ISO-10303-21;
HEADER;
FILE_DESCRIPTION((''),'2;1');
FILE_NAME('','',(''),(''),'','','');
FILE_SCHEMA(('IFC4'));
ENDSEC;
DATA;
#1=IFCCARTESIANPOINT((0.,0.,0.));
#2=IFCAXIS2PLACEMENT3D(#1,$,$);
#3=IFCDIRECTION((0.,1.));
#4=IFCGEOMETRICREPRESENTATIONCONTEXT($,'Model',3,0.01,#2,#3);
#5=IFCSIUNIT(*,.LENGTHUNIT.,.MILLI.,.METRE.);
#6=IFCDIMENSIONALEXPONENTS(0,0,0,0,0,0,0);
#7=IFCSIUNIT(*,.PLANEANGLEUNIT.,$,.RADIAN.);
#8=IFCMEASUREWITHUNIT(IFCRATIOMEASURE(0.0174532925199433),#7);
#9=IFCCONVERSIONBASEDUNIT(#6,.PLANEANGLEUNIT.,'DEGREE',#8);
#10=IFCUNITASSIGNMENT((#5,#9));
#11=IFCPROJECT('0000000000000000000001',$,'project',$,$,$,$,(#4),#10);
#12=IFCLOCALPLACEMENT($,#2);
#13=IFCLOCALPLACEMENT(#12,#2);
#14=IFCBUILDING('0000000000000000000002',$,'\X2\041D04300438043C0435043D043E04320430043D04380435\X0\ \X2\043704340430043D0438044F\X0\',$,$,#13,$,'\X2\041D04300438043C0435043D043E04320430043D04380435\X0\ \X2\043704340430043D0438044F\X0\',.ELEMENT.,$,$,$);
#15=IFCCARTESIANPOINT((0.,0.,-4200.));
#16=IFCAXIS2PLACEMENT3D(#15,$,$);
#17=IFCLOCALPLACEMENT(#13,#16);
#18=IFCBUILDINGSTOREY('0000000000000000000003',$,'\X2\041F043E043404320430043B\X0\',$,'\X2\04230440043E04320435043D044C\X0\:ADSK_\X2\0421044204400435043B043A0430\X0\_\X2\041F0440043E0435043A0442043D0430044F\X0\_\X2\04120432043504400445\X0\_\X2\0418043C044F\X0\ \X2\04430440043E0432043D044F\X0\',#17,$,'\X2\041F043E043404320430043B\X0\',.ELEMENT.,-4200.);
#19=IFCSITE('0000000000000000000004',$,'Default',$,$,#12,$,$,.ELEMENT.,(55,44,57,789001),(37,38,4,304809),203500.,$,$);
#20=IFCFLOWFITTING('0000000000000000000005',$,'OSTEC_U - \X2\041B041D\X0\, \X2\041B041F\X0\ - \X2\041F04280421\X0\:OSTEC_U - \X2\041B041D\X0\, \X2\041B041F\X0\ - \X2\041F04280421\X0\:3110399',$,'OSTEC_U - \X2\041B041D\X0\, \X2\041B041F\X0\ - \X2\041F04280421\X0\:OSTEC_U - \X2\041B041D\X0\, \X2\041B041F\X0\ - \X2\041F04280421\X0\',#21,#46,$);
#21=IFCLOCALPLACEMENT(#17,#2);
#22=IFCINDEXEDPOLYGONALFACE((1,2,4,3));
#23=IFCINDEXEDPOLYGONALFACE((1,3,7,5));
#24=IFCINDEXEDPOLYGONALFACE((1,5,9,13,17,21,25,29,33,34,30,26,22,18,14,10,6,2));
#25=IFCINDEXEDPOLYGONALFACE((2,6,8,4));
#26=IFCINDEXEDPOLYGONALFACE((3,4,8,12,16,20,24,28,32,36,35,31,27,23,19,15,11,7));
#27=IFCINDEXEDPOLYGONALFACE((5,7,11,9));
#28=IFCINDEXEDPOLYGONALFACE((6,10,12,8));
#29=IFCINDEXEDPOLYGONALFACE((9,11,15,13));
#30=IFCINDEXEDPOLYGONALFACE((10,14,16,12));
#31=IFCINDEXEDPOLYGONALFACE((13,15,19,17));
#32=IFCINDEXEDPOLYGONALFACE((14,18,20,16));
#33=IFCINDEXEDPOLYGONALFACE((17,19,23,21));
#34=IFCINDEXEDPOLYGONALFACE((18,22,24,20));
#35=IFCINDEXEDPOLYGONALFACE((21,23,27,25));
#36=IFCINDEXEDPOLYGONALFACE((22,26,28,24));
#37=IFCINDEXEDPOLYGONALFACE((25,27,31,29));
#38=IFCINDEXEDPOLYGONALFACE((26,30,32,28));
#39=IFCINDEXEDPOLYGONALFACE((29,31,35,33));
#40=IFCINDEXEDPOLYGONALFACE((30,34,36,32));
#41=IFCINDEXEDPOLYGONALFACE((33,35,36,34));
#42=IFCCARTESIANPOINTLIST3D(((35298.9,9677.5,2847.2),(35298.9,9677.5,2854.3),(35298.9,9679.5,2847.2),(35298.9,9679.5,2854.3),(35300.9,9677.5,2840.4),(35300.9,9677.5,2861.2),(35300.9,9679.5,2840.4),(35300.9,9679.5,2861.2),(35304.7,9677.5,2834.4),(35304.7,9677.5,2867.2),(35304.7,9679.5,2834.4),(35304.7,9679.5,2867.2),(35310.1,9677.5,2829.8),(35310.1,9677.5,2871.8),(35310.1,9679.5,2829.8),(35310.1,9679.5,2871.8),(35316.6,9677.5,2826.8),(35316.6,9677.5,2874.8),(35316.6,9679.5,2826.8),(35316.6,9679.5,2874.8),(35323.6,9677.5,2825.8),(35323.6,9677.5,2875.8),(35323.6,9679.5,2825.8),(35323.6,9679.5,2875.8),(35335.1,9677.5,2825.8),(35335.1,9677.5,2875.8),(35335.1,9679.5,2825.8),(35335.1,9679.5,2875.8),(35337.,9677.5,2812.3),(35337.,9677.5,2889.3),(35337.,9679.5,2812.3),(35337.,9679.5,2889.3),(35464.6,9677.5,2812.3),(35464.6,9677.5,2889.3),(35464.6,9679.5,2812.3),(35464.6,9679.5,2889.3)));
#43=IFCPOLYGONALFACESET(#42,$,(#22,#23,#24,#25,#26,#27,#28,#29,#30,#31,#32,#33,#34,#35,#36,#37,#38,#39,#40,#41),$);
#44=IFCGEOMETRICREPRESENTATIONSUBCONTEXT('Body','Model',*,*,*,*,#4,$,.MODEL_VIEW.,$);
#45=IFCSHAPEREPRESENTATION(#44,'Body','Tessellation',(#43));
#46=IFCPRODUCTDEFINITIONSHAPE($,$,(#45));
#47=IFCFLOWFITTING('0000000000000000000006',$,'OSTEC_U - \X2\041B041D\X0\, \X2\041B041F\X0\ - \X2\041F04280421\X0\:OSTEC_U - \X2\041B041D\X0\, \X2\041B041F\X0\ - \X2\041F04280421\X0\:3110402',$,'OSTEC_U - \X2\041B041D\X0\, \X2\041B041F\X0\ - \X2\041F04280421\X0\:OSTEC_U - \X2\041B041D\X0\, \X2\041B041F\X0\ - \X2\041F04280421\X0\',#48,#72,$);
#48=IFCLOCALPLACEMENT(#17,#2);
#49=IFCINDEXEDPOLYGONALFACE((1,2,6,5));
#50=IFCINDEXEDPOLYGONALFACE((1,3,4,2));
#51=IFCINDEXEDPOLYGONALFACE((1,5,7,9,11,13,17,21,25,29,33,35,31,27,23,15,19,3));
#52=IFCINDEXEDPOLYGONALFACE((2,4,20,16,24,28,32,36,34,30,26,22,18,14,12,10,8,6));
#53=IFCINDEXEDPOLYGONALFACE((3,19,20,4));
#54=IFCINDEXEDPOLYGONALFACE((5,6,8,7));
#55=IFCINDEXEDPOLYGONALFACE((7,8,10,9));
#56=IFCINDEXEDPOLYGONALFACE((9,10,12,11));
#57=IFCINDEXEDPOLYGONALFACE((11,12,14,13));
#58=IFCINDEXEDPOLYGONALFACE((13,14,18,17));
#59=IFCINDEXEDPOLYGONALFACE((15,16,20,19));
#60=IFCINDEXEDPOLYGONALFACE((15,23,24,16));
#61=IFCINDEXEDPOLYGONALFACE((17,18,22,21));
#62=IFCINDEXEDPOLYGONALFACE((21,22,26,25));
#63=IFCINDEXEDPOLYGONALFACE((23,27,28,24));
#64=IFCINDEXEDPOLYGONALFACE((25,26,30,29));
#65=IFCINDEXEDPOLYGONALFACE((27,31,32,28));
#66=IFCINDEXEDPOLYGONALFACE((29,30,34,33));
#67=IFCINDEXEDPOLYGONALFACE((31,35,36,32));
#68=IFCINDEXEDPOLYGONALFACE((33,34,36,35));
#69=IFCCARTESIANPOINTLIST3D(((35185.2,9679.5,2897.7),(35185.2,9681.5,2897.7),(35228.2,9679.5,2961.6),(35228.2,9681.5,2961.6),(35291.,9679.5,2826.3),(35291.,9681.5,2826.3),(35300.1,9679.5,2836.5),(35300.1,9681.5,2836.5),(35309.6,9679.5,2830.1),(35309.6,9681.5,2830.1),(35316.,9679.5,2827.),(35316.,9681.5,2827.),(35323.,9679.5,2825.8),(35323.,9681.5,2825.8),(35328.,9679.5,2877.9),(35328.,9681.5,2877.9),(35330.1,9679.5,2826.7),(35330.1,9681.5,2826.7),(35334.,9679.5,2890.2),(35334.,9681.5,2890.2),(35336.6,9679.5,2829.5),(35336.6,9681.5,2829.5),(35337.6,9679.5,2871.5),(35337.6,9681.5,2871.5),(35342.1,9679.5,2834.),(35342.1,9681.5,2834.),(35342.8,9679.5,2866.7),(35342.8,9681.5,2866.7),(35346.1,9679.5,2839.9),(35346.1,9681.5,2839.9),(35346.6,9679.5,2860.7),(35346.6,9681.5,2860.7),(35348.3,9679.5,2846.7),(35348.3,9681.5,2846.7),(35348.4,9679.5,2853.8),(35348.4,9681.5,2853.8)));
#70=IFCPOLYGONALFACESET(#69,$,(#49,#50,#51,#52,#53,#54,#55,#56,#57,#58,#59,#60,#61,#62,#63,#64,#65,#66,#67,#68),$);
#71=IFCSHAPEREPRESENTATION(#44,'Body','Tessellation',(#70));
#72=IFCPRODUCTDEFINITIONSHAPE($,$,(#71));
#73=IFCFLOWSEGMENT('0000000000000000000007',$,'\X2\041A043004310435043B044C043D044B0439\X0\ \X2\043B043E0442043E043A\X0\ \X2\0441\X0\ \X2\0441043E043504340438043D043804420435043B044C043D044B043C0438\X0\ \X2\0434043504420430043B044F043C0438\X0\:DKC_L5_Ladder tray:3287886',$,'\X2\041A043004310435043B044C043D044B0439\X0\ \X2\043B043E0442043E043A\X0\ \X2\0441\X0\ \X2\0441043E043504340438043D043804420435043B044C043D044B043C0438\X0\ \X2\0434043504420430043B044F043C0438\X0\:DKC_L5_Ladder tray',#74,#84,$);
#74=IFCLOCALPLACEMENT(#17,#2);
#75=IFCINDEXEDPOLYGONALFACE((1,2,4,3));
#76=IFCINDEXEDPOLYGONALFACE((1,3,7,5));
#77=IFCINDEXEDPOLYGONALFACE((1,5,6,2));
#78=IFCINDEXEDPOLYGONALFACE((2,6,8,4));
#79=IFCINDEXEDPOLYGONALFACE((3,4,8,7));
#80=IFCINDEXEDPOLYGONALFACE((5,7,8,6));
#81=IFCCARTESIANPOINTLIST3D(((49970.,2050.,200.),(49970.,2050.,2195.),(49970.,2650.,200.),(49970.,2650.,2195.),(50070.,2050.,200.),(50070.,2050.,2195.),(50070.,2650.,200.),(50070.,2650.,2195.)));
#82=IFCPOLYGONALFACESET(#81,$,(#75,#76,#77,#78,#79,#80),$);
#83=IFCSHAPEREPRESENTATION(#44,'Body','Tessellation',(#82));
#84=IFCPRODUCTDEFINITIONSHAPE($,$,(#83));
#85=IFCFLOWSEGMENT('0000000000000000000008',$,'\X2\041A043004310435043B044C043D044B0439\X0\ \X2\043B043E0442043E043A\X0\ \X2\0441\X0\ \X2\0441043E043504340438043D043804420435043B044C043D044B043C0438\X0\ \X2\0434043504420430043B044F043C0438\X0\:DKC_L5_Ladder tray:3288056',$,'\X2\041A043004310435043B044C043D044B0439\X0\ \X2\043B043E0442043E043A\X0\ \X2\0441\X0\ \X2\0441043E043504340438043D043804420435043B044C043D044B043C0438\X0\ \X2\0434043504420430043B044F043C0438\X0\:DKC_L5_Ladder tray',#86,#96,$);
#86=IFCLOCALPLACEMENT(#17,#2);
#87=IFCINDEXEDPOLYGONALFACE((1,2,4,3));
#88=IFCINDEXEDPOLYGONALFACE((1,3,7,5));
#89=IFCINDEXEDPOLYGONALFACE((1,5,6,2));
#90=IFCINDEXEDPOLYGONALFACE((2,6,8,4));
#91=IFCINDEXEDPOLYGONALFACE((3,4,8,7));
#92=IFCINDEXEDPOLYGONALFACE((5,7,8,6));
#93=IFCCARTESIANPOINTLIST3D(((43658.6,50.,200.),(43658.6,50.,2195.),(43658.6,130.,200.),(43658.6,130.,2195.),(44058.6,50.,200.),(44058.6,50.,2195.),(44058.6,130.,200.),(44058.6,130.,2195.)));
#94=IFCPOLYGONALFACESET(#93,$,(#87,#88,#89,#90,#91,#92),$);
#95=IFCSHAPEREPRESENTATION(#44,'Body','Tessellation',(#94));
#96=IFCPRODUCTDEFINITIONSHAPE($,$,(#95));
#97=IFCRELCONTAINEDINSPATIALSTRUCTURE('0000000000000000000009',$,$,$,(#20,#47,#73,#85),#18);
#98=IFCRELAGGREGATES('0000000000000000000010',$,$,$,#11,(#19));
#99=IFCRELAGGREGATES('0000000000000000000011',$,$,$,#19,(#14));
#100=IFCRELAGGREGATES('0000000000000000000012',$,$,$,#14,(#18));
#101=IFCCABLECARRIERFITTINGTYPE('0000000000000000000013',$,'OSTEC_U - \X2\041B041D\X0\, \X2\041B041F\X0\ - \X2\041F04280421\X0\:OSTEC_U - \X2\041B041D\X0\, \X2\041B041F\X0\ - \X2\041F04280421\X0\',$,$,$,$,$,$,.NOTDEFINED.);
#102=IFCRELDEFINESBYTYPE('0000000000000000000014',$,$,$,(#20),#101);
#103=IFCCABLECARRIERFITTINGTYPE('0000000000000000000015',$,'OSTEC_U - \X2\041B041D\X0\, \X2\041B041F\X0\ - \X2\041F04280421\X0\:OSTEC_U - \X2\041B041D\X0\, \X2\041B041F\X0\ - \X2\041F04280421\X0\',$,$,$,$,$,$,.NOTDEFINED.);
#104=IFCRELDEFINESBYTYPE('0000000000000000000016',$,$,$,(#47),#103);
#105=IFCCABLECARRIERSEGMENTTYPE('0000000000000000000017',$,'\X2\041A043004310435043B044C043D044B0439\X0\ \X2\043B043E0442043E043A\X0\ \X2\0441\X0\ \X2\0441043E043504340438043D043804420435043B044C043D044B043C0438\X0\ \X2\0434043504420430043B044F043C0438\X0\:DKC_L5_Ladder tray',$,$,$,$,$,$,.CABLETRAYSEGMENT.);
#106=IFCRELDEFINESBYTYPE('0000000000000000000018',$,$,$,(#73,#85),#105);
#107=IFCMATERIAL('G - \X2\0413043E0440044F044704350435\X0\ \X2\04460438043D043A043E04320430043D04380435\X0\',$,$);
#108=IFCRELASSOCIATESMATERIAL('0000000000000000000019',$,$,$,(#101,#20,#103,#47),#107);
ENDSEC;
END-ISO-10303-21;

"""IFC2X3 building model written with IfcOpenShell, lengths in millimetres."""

from ifc_helpers import new_model, entity, si_unit, converted_unit, direction, frame, frame_2d, origin, origin_2d_with_axis, place, context, subcontext, project, spatial, polyline, circle_curve, parameter, trimmed, segment, composite_curve, rectangle, outline, extrude, source, transform, mapped, material, type_object, type_shapes, element, save


model = new_model("IFC2X3")

# Units and contexts
model_context = context("Model", 3, precision=0.01, world=origin(), true_north=direction((0.0, 1.0)))
body_context = subcontext(model_context, "Body", "Model", "MODEL_VIEW")
ifc_project = project(units=[si_unit("LENGTHUNIT", "METRE", prefix="MILLI"), converted_unit("PLANEANGLEUNIT", "DEGREE", entity("IfcRatioMeasure", 0.0174532925199433), si_unit("PLANEANGLEUNIT", "RADIAN"), dimensions=[0, 0, 0, 0, 0, 0, 0])], contexts=[model_context])

# Site, building, storey
site_placement = place(None, frame((0.0, 0.0, 0.0)))
site = spatial("IfcSite", under=ifc_project, at=site_placement, Name="Default", CompositionType="ELEMENT", RefLatitude=(55, 44, 57, 789001), RefLongitude=(37, 38, 4, 304809), RefElevation=203500.0)
building_placement = place(site_placement, origin())
building = spatial("IfcBuilding", under=site, at=building_placement, Name="Наименование здания", LongName="Наименование здания", CompositionType="ELEMENT")
storey_placement = place(building_placement, frame((0.0, 0.0, -4200.0)))
storey = spatial("IfcBuildingStorey", under=building, at=storey_placement, Name="Подвал", ObjectType="Уровень:ADSK_Стрелка_Проектная_Вверх_Имя уровня", LongName="Подвал", CompositionType="ELEMENT", Elevation=-4200.0)

# Flow fittings
ifc_material_1 = material(Name="G - Горячее цинкование")
cable_carrier_fitting_type_1 = type_object("IfcCableCarrierFittingType", Name="OSTEC_U - ЛН, ЛП - ПШС:OSTEC_U - ЛН, ЛП - ПШС", PredefinedType="NOTDEFINED", material=ifc_material_1)
shared_shape_1 = source(origin(), body_context, "Body", "SweptSolid", [
    extrude(outline(composite_curve([segment(trimmed(circle_curve(frame_2d((-41.5, 0.0), x_axis=(1.0, 0.0)), 25.0), [parameter(90.0)], [parameter(270.0)], True, "PARAMETER"), True, "CONTINUOUS"), segment(polyline([(-41.5, -25.0), (-30.0, -25.0)]), True, "CONTINUOUS"), segment(polyline([(-30.0, -25.0), (-28.1, -38.5)]), True, "CONTINUOUS"), segment(polyline([(-28.1, -38.5), (99.5, -38.5)]), True, "CONTINUOUS"), segment(polyline([(99.5, -38.5), (99.5, 38.5)]), True, "CONTINUOUS"), segment(polyline([(99.5, 38.5), (-28.1, 38.5)]), True, "CONTINUOUS"), segment(polyline([(-28.1, 38.5), (-30.0, 25.0)]), True, "CONTINUOUS"), segment(polyline([(-30.0, 25.0), (-41.5, 25.0)]), True, "CONTINUOUS")], self_intersect=False)), frame((41.5, 0.0, 0.0), z_axis=(0.0, 0.0, -1.0), x_axis=(1.0, 0.0, 0.0)), (0.0, 0.0, -1.0), 2.0),
])
type_shapes(cable_carrier_fitting_type_1, [shared_shape_1])
flow_fitting_1_placement = place(storey_placement, frame((35323.6, 9679.5, 2850.8), z_axis=(0.0, -1.0, 0.0), x_axis=(1.0, 0.0, -0.00005)))
element("IfcFlowFitting", 1, at=flow_fitting_1_placement, inside=storey, type_object=cable_carrier_fitting_type_1, material=ifc_material_1, Name="OSTEC_U - ЛН, ЛП - ПШС:OSTEC_U - ЛН, ЛП - ПШС:3110399", ObjectType="OSTEC_U - ЛН, ЛП - ПШС:OSTEC_U - ЛН, ЛП - ПШС", context=body_context, shape_type="MappedRepresentation", body=[
    mapped(shared_shape_1, transform((0.0, 0.0, 0.0), scale=1.0)),
])
cable_carrier_fitting_type_2 = type_object("IfcCableCarrierFittingType", Name="OSTEC_U - ЛН, ЛП - ПШС:OSTEC_U - ЛН, ЛП - ПШС", PredefinedType="NOTDEFINED", material=ifc_material_1)
shared_shape_2 = source(origin(), body_context, "Body", "SweptSolid", [
    extrude(outline(composite_curve([segment(trimmed(circle_curve(frame_2d((-41.5, 0.0), x_axis=(1.0, 0.0)), 25.0), [parameter(90.0)], [parameter(270.0)], True, "PARAMETER"), True, "CONTINUOUS"), segment(polyline([(-41.5, -25.0), (-30.0, -25.0)]), True, "CONTINUOUS"), segment(polyline([(-30.0, -25.0), (-28.1, -38.5)]), True, "CONTINUOUS"), segment(polyline([(-28.1, -38.5), (99.5, -38.5)]), True, "CONTINUOUS"), segment(polyline([(99.5, -38.5), (99.5, 38.5)]), True, "CONTINUOUS"), segment(polyline([(99.5, 38.5), (-28.1, 38.5)]), True, "CONTINUOUS"), segment(polyline([(-28.1, 38.5), (-30.0, 25.0)]), True, "CONTINUOUS"), segment(polyline([(-30.0, 25.0), (-41.5, 25.0)]), True, "CONTINUOUS")], self_intersect=False)), frame((41.5, 0.0, 0.0)), (0.0, 0.0, 1.0), 2.0),
])
type_shapes(cable_carrier_fitting_type_2, [shared_shape_2])
flow_fitting_2_placement = place(storey_placement, frame((35323.6, 9681.5, 2850.8), z_axis=(0.0, -1.0, 0.0), x_axis=(-0.829038, 0.0, 0.559193)))
element("IfcFlowFitting", 2, at=flow_fitting_2_placement, inside=storey, type_object=cable_carrier_fitting_type_2, material=ifc_material_1, Name="OSTEC_U - ЛН, ЛП - ПШС:OSTEC_U - ЛН, ЛП - ПШС:3110402", ObjectType="OSTEC_U - ЛН, ЛП - ПШС:OSTEC_U - ЛН, ЛП - ПШС", context=body_context, shape_type="MappedRepresentation", body=[
    mapped(shared_shape_2, transform((0.0, 0.0, 0.0), scale=1.0)),
])

# Flow segments
cable_carrier_segment_type_1 = type_object("IfcCableCarrierSegmentType", Name="Кабельный лоток с соединительными деталями:DKC_L5_Ladder tray", PredefinedType="CABLETRAYSEGMENT")
flow_segment_1_placement = place(storey_placement, frame((49970.0, 2050.0, 200.0)))
element("IfcFlowSegment", 3, at=flow_segment_1_placement, inside=storey, type_object=cable_carrier_segment_type_1, Name="Кабельный лоток с соединительными деталями:DKC_L5_Ladder tray:3287886", ObjectType="Кабельный лоток с соединительными деталями:DKC_L5_Ladder tray", context=body_context, shape_type="SweptSolid", body=[
    extrude(rectangle(XDim=600.0, YDim=100.0, at=origin_2d_with_axis()), frame((50.0, 300.0, 0.0), z_axis=(0.0, 0.0, 1.0), x_axis=(0.0, 1.0, 0.0)), (0.0, 0.0, 1.0), 1995.0),
])
flow_segment_2_placement = place(storey_placement, frame((43658.6, 50.0, 200.0)))
element("IfcFlowSegment", 4, at=flow_segment_2_placement, inside=storey, type_object=cable_carrier_segment_type_1, Name="Кабельный лоток с соединительными деталями:DKC_L5_Ladder tray:3288056", ObjectType="Кабельный лоток с соединительными деталями:DKC_L5_Ladder tray", context=body_context, shape_type="SweptSolid", body=[
    extrude(rectangle(XDim=400.0, YDim=80.0, at=origin_2d_with_axis()), frame((200.0, 40.0, 0.0)), (0.0, 0.0, 1.0), 1995.0),
])

save(model, "model.ifc")
